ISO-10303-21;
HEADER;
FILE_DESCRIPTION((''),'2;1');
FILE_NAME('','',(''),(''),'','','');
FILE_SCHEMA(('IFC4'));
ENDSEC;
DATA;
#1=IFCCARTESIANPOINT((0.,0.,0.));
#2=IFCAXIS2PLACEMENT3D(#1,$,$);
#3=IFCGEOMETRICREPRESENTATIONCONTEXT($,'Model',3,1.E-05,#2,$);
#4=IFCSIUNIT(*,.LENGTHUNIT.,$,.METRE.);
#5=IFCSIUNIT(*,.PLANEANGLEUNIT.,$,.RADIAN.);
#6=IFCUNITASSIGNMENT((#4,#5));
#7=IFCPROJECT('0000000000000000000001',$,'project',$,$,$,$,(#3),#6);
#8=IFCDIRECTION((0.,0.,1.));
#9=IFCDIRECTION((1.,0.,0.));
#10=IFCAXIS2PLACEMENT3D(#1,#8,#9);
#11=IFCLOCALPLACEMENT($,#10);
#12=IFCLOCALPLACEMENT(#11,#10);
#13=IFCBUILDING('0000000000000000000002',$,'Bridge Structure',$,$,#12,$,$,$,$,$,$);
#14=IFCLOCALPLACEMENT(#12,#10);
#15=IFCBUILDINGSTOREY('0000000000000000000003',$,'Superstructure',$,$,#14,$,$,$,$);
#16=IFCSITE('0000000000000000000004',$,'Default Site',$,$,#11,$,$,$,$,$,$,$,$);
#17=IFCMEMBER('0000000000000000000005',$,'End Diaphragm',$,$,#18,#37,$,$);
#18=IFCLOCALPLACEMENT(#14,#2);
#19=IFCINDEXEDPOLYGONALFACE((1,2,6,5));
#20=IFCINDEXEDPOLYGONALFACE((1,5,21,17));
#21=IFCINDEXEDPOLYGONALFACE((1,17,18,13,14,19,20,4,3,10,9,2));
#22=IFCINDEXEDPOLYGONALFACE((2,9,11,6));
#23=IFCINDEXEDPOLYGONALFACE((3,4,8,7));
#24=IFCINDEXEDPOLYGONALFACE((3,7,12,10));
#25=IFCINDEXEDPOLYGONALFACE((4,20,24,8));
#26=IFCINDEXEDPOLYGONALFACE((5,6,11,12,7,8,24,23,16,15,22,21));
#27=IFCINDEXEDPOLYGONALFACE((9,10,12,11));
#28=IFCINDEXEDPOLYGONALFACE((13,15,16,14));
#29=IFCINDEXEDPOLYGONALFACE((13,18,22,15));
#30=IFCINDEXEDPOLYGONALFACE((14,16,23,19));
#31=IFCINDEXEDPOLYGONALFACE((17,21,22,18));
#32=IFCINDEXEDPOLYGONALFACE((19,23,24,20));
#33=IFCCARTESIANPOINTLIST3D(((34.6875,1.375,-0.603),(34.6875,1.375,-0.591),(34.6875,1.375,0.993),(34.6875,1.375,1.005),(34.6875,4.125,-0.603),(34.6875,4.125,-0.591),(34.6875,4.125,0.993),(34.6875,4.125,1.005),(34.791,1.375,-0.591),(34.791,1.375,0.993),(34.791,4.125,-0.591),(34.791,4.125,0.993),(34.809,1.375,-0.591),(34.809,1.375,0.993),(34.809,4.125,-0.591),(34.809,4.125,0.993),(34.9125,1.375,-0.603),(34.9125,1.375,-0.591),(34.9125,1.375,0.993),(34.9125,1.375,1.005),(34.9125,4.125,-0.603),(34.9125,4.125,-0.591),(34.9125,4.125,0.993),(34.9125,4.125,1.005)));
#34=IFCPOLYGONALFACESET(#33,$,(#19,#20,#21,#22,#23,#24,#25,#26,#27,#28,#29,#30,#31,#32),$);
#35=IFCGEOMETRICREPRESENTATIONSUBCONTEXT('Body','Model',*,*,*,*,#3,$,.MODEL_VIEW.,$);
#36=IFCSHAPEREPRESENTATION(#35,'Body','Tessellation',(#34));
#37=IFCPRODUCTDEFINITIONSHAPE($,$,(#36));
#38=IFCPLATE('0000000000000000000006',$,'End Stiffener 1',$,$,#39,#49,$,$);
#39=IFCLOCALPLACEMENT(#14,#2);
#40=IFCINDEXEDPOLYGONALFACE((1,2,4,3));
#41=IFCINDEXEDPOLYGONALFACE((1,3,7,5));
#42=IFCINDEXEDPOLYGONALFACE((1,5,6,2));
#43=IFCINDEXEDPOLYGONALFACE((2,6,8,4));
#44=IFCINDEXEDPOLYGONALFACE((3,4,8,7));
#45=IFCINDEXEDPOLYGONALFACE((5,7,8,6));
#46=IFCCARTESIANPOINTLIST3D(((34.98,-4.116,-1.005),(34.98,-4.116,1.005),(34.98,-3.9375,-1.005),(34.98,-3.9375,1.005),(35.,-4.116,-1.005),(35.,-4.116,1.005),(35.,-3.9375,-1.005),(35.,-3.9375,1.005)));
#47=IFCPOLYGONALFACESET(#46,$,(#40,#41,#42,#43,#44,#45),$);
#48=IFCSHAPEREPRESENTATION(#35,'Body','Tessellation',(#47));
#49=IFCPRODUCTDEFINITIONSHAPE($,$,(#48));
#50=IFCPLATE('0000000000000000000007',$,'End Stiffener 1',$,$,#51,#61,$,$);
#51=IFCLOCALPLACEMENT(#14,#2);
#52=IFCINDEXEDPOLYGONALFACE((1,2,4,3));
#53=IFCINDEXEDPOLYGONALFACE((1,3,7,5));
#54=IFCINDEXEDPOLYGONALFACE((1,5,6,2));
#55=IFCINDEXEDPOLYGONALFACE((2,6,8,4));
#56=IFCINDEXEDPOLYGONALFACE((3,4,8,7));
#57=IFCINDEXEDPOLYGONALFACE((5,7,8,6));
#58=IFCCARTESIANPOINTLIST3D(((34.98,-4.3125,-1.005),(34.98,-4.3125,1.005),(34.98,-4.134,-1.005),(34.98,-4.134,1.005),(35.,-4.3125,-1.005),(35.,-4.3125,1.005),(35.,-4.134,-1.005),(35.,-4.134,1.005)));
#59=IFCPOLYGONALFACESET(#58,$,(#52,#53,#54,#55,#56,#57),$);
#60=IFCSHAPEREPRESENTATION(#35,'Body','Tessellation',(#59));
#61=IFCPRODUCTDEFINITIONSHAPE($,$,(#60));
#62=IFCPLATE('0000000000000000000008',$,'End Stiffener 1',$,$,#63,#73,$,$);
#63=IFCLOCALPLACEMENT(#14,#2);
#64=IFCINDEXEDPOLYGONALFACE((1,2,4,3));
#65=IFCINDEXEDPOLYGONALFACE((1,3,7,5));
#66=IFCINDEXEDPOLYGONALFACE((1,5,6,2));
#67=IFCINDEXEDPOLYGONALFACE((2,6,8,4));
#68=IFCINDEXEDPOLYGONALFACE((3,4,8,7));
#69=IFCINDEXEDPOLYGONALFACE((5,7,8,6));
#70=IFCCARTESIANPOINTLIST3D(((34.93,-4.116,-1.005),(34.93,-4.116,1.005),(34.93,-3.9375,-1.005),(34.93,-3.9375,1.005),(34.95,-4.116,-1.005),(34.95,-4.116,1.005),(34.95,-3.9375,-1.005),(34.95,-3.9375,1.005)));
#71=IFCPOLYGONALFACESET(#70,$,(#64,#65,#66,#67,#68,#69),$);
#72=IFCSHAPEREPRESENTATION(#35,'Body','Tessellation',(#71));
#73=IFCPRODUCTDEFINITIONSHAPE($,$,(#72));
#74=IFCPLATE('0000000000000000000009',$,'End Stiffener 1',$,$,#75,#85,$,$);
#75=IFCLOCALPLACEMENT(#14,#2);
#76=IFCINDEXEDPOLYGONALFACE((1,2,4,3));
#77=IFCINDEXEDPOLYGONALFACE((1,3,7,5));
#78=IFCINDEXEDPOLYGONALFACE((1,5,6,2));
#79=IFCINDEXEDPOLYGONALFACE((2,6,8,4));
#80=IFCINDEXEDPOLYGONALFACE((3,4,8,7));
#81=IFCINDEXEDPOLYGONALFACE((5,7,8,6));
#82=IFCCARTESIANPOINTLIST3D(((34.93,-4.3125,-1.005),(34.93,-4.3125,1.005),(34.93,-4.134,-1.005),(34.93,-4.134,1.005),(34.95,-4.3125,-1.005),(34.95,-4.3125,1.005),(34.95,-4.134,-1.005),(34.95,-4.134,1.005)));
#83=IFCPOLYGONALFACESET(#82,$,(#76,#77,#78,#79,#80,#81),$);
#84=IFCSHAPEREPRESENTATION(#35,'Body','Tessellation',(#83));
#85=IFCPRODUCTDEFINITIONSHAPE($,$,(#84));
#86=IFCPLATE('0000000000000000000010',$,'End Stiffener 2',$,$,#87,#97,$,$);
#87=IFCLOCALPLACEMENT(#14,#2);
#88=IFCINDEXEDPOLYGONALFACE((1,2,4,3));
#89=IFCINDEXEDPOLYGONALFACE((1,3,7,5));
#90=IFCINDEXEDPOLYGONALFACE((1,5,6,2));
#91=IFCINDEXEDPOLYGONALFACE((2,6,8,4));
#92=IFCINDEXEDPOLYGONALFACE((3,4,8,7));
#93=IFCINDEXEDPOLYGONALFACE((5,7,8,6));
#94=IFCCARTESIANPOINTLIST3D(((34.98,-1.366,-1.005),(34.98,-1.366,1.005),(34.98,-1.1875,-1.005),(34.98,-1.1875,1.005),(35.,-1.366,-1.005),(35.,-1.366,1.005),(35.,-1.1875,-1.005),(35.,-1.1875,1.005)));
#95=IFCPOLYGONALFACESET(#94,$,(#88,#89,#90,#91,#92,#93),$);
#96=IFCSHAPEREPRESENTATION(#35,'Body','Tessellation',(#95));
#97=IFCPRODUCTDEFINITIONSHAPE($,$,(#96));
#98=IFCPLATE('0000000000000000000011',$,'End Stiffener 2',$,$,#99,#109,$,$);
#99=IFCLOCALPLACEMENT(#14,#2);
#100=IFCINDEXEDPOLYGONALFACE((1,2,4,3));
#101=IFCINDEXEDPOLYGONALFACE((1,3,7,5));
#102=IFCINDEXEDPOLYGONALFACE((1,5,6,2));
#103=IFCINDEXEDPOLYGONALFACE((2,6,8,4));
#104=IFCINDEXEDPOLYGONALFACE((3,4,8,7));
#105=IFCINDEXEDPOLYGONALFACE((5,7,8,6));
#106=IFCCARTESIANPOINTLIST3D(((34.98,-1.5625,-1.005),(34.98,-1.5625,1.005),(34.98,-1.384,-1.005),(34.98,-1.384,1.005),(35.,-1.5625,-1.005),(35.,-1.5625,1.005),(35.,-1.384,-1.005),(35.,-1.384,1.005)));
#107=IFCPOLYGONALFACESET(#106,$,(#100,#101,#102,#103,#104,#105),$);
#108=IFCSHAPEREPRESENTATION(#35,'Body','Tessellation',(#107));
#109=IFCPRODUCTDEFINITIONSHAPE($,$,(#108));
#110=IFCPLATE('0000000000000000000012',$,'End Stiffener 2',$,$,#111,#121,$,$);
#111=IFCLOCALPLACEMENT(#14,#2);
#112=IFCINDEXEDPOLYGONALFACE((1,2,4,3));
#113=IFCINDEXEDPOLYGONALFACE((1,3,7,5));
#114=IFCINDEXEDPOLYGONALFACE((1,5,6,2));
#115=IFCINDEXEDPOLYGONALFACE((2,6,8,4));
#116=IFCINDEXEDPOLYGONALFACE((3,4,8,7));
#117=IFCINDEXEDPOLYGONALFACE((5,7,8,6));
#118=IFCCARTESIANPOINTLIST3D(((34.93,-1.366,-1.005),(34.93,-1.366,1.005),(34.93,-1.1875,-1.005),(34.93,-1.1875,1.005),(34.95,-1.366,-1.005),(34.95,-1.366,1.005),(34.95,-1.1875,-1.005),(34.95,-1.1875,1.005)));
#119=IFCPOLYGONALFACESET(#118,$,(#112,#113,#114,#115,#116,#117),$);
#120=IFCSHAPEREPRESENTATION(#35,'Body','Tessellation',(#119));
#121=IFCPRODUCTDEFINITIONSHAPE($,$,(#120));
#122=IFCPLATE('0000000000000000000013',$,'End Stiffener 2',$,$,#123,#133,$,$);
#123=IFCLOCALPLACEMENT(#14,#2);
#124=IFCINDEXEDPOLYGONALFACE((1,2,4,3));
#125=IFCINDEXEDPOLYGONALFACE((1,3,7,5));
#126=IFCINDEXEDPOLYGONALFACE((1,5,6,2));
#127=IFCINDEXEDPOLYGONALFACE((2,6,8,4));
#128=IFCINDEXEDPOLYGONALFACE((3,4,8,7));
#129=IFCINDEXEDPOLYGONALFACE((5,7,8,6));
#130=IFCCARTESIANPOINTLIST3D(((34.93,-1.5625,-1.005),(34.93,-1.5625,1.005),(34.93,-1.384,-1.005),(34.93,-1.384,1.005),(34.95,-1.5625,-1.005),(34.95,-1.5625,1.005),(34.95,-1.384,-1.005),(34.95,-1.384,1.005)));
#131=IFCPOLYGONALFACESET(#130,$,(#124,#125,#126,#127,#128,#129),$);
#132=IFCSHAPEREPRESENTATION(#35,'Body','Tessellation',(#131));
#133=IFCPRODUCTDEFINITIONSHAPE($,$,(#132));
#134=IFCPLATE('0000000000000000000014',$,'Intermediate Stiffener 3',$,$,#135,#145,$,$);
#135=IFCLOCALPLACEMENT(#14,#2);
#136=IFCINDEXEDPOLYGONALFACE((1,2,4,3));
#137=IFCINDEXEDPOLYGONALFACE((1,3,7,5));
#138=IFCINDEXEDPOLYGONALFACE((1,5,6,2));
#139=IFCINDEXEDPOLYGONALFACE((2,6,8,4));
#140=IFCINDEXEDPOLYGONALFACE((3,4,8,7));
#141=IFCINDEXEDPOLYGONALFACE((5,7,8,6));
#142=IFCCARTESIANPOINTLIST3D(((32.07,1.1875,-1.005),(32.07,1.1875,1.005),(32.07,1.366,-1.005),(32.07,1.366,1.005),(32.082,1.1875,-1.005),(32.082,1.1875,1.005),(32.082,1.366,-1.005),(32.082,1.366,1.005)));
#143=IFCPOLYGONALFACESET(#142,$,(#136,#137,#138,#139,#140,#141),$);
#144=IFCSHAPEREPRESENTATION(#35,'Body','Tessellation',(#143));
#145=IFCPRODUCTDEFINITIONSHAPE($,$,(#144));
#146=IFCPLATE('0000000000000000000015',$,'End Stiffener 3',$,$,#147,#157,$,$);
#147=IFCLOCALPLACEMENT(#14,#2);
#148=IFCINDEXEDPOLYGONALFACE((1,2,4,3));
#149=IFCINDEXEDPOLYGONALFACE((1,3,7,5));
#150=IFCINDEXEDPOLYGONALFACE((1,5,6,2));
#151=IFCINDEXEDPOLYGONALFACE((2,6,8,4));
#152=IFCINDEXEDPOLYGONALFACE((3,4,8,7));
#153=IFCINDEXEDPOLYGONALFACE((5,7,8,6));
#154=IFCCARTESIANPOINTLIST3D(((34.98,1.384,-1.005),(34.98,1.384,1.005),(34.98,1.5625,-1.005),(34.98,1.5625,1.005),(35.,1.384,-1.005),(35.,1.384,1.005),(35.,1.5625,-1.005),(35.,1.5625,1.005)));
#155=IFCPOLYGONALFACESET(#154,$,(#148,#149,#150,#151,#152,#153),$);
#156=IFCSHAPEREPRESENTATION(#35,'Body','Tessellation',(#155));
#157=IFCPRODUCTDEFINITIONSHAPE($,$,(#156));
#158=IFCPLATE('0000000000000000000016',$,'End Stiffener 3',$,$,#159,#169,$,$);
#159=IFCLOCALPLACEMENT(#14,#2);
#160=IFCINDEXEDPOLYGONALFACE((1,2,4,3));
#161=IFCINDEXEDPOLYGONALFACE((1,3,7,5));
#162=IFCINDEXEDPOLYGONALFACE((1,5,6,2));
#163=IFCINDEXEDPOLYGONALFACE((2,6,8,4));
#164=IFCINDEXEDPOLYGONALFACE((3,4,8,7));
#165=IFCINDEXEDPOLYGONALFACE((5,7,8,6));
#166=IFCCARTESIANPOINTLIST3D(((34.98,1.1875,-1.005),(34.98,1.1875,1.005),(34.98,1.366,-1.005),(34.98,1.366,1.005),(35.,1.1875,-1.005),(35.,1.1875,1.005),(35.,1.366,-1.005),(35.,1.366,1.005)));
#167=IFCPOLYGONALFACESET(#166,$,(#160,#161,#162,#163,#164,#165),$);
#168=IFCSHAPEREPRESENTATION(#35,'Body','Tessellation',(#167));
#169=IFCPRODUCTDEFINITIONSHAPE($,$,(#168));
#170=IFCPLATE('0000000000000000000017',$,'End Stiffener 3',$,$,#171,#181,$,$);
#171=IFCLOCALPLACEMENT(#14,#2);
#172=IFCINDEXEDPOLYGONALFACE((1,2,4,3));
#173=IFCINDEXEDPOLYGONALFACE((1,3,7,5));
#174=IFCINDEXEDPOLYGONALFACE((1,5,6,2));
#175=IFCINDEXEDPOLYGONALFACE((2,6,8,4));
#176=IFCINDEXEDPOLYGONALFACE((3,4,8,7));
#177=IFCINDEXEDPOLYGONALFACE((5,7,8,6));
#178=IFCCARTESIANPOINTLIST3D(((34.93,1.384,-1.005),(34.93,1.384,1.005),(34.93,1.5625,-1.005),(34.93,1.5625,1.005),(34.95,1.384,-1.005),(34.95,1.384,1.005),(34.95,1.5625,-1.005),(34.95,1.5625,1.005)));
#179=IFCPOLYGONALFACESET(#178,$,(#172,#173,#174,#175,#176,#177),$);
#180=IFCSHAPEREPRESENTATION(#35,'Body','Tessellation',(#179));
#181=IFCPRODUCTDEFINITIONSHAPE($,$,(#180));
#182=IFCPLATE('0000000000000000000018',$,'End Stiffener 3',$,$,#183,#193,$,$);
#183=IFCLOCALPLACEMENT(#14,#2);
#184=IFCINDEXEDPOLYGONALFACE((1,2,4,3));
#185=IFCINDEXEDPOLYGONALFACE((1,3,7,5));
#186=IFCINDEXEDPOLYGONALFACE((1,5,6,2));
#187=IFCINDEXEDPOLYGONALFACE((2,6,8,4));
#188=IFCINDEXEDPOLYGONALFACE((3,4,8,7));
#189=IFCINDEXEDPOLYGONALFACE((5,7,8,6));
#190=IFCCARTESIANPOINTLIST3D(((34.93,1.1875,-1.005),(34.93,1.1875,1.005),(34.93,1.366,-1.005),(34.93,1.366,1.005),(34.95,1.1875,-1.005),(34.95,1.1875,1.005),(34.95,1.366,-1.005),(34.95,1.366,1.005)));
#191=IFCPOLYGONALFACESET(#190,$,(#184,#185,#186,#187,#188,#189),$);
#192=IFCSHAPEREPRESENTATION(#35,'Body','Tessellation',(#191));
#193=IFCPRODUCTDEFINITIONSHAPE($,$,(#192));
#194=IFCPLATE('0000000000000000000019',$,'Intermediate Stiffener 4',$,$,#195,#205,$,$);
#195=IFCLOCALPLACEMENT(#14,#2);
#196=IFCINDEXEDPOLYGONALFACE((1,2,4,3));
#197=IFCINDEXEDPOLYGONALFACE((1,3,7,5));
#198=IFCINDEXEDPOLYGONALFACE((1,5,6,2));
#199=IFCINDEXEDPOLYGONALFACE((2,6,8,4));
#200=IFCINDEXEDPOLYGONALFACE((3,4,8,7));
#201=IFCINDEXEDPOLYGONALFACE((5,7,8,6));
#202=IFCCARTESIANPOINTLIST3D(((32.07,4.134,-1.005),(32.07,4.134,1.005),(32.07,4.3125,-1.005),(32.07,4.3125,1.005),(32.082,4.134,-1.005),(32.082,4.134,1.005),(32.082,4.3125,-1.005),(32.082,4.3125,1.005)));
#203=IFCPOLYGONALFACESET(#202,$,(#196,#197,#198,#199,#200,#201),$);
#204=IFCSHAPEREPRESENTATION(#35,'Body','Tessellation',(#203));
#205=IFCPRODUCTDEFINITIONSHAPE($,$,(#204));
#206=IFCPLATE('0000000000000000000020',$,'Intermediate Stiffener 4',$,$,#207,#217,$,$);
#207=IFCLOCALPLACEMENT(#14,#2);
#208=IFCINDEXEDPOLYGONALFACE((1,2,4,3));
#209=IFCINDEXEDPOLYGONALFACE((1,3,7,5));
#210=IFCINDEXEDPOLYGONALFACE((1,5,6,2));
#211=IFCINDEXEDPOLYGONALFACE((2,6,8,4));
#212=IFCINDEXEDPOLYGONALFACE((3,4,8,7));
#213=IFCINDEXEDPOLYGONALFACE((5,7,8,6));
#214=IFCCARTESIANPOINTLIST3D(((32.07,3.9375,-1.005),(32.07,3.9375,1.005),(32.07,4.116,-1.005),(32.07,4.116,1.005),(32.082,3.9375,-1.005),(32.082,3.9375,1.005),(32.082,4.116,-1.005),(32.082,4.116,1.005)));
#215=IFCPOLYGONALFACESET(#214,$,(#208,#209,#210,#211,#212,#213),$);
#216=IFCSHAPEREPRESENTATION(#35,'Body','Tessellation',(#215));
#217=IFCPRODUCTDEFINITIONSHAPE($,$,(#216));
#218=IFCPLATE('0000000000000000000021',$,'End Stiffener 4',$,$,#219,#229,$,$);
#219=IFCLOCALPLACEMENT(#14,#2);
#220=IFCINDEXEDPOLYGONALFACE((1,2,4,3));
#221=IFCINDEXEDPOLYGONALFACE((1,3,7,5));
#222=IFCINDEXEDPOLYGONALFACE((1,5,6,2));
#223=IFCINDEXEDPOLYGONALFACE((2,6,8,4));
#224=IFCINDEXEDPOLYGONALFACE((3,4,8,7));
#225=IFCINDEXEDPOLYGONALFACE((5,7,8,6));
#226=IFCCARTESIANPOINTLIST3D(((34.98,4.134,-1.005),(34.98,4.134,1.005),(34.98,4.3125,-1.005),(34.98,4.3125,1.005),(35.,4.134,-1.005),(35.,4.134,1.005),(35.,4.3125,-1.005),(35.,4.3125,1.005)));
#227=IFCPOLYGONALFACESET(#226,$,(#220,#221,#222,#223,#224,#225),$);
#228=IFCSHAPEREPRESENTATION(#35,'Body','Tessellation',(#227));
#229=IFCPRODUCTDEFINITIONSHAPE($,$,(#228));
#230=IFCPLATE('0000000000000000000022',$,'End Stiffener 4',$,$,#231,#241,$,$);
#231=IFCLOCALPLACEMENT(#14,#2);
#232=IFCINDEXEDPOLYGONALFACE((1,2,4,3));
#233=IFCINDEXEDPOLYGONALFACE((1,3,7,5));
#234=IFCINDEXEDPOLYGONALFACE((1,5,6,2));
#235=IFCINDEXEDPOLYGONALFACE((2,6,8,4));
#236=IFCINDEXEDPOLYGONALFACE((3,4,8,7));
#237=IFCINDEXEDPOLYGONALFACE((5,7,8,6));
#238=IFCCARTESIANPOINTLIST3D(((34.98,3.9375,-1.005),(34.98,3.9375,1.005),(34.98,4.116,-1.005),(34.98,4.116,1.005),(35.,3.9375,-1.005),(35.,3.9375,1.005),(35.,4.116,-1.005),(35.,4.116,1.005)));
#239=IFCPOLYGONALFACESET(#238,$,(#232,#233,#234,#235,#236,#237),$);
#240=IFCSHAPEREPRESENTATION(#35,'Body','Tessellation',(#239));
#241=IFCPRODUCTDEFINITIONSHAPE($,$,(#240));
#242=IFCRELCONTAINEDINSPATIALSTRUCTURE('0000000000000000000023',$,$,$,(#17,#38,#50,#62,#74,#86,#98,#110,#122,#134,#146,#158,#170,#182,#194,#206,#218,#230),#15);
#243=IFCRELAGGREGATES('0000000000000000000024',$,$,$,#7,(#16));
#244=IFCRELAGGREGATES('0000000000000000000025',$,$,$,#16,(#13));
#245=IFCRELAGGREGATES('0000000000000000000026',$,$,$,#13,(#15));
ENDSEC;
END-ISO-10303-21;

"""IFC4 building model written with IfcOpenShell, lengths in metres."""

from ifc_helpers import new_model, si_unit, frame, origin, origin_with_axes, origin_2d_with_axis, place, context, subcontext, project, spatial, rectangle, i_section, extrude, element, save


model = new_model("IFC4")

# Units and contexts
model_context = context("Model", 3, precision=1e-05, world=origin())
body_context = subcontext(model_context, "Body", "Model", "MODEL_VIEW")
ifc_project = project(units=[si_unit("LENGTHUNIT", "METRE"), si_unit("PLANEANGLEUNIT", "RADIAN")], contexts=[model_context])

# Site, building, storey
site_placement = place(None, origin_with_axes())
site = spatial("IfcSite", under=ifc_project, at=site_placement, Name="Default Site")
building_placement = place(site_placement, origin_with_axes())
building = spatial("IfcBuilding", under=site, at=building_placement, Name="Bridge Structure")
storey_placement = place(building_placement, origin_with_axes())
storey = spatial("IfcBuildingStorey", under=building, at=storey_placement, Name="Superstructure")

# Member
for number, where, z_axis, x_axis, name in (
    (1, (34.8, 1.375, 0.201), (0.0, 1.0, 0.0), (-1.0, 0.0, 0.0), "End Diaphragm"),
):
    element("IfcMember", number, at=place(storey_placement, frame(where, z_axis=z_axis, x_axis=x_axis)), inside=storey, Name=name, context=body_context, shape_type="SweptSolid", body=[
        extrude(i_section(OverallWidth=0.225, OverallDepth=1.608, WebThickness=0.018, FlangeThickness=0.012, at=origin_2d_with_axis()), origin_with_axes(), (0.0, 0.0, 1.0), 2.75),
    ])

# Plates
for number, where, z_axis, x_axis, name in (
    (2, (34.99, -4.0267, -1.005), (0.0, 0.0, 1.0), (1.0, 0.0, 0.0), "End Stiffener 1"),
    (3, (34.99, -4.2233, -1.005), (0.0, 0.0, 1.0), (1.0, 0.0, 0.0), "End Stiffener 1"),
    (4, (34.94, -4.0267, -1.005), (0.0, 0.0, 1.0), (1.0, 0.0, 0.0), "End Stiffener 1"),
    (5, (34.94, -4.2233, -1.005), (0.0, 0.0, 1.0), (1.0, 0.0, 0.0), "End Stiffener 1"),
    (6, (34.99, -1.2768, -1.005), (0.0, 0.0, 1.0), (1.0, 0.0, 0.0), "End Stiffener 2"),
    (7, (34.99, -1.4732, -1.005), (0.0, 0.0, 1.0), (1.0, 0.0, 0.0), "End Stiffener 2"),
    (8, (34.94, -1.2768, -1.005), (0.0, 0.0, 1.0), (1.0, 0.0, 0.0), "End Stiffener 2"),
    (9, (34.94, -1.4732, -1.005), (0.0, 0.0, 1.0), (1.0, 0.0, 0.0), "End Stiffener 2"),
):
    element("IfcPlate", number, at=place(storey_placement, frame(where, z_axis=z_axis, x_axis=x_axis)), inside=storey, Name=name, context=body_context, shape_type="SweptSolid", body=[
        extrude(rectangle(XDim=0.02, YDim=0.1785, at=origin_2d_with_axis()), origin_with_axes(), (0.0, 0.0, 1.0), 2.01),
    ])
plate_placement = place(storey_placement, frame((32.076, 1.2768, -1.005), z_axis=(0.0, 0.0, 1.0), x_axis=(1.0, 0.0, 0.0)))
element("IfcPlate", 10, at=plate_placement, inside=storey, Name="Intermediate Stiffener 3", context=body_context, shape_type="SweptSolid", body=[
    extrude(rectangle(XDim=0.012, YDim=0.1785, at=origin_2d_with_axis()), origin_with_axes(), (0.0, 0.0, 1.0), 2.01),
])
for number, where, z_axis, x_axis, name in (
    (11, (34.99, 1.4732, -1.005), (0.0, 0.0, 1.0), (1.0, 0.0, 0.0), "End Stiffener 3"),
    (12, (34.99, 1.2768, -1.005), (0.0, 0.0, 1.0), (1.0, 0.0, 0.0), "End Stiffener 3"),
    (13, (34.94, 1.4732, -1.005), (0.0, 0.0, 1.0), (1.0, 0.0, 0.0), "End Stiffener 3"),
    (14, (34.94, 1.2768, -1.005), (0.0, 0.0, 1.0), (1.0, 0.0, 0.0), "End Stiffener 3"),
):
    element("IfcPlate", number, at=place(storey_placement, frame(where, z_axis=z_axis, x_axis=x_axis)), inside=storey, Name=name, context=body_context, shape_type="SweptSolid", body=[
        extrude(rectangle(XDim=0.02, YDim=0.1785, at=origin_2d_with_axis()), origin_with_axes(), (0.0, 0.0, 1.0), 2.01),
    ])
for number, where, z_axis, x_axis, name in (
    (15, (32.076, 4.2233, -1.005), (0.0, 0.0, 1.0), (1.0, 0.0, 0.0), "Intermediate Stiffener 4"),
    (16, (32.076, 4.0267, -1.005), (0.0, 0.0, 1.0), (1.0, 0.0, 0.0), "Intermediate Stiffener 4"),
):
    element("IfcPlate", number, at=place(storey_placement, frame(where, z_axis=z_axis, x_axis=x_axis)), inside=storey, Name=name, context=body_context, shape_type="SweptSolid", body=[
        extrude(rectangle(XDim=0.012, YDim=0.1785, at=origin_2d_with_axis()), origin_with_axes(), (0.0, 0.0, 1.0), 2.01),
    ])
for number, where, z_axis, x_axis, name in (
    (17, (34.99, 4.2233, -1.005), (0.0, 0.0, 1.0), (1.0, 0.0, 0.0), "End Stiffener 4"),
    (18, (34.99, 4.0267, -1.005), (0.0, 0.0, 1.0), (1.0, 0.0, 0.0), "End Stiffener 4"),
):
    element("IfcPlate", number, at=place(storey_placement, frame(where, z_axis=z_axis, x_axis=x_axis)), inside=storey, Name=name, context=body_context, shape_type="SweptSolid", body=[
        extrude(rectangle(XDim=0.02, YDim=0.1785, at=origin_2d_with_axis()), origin_with_axes(), (0.0, 0.0, 1.0), 2.01),
    ])

save(model, "model.ifc")
